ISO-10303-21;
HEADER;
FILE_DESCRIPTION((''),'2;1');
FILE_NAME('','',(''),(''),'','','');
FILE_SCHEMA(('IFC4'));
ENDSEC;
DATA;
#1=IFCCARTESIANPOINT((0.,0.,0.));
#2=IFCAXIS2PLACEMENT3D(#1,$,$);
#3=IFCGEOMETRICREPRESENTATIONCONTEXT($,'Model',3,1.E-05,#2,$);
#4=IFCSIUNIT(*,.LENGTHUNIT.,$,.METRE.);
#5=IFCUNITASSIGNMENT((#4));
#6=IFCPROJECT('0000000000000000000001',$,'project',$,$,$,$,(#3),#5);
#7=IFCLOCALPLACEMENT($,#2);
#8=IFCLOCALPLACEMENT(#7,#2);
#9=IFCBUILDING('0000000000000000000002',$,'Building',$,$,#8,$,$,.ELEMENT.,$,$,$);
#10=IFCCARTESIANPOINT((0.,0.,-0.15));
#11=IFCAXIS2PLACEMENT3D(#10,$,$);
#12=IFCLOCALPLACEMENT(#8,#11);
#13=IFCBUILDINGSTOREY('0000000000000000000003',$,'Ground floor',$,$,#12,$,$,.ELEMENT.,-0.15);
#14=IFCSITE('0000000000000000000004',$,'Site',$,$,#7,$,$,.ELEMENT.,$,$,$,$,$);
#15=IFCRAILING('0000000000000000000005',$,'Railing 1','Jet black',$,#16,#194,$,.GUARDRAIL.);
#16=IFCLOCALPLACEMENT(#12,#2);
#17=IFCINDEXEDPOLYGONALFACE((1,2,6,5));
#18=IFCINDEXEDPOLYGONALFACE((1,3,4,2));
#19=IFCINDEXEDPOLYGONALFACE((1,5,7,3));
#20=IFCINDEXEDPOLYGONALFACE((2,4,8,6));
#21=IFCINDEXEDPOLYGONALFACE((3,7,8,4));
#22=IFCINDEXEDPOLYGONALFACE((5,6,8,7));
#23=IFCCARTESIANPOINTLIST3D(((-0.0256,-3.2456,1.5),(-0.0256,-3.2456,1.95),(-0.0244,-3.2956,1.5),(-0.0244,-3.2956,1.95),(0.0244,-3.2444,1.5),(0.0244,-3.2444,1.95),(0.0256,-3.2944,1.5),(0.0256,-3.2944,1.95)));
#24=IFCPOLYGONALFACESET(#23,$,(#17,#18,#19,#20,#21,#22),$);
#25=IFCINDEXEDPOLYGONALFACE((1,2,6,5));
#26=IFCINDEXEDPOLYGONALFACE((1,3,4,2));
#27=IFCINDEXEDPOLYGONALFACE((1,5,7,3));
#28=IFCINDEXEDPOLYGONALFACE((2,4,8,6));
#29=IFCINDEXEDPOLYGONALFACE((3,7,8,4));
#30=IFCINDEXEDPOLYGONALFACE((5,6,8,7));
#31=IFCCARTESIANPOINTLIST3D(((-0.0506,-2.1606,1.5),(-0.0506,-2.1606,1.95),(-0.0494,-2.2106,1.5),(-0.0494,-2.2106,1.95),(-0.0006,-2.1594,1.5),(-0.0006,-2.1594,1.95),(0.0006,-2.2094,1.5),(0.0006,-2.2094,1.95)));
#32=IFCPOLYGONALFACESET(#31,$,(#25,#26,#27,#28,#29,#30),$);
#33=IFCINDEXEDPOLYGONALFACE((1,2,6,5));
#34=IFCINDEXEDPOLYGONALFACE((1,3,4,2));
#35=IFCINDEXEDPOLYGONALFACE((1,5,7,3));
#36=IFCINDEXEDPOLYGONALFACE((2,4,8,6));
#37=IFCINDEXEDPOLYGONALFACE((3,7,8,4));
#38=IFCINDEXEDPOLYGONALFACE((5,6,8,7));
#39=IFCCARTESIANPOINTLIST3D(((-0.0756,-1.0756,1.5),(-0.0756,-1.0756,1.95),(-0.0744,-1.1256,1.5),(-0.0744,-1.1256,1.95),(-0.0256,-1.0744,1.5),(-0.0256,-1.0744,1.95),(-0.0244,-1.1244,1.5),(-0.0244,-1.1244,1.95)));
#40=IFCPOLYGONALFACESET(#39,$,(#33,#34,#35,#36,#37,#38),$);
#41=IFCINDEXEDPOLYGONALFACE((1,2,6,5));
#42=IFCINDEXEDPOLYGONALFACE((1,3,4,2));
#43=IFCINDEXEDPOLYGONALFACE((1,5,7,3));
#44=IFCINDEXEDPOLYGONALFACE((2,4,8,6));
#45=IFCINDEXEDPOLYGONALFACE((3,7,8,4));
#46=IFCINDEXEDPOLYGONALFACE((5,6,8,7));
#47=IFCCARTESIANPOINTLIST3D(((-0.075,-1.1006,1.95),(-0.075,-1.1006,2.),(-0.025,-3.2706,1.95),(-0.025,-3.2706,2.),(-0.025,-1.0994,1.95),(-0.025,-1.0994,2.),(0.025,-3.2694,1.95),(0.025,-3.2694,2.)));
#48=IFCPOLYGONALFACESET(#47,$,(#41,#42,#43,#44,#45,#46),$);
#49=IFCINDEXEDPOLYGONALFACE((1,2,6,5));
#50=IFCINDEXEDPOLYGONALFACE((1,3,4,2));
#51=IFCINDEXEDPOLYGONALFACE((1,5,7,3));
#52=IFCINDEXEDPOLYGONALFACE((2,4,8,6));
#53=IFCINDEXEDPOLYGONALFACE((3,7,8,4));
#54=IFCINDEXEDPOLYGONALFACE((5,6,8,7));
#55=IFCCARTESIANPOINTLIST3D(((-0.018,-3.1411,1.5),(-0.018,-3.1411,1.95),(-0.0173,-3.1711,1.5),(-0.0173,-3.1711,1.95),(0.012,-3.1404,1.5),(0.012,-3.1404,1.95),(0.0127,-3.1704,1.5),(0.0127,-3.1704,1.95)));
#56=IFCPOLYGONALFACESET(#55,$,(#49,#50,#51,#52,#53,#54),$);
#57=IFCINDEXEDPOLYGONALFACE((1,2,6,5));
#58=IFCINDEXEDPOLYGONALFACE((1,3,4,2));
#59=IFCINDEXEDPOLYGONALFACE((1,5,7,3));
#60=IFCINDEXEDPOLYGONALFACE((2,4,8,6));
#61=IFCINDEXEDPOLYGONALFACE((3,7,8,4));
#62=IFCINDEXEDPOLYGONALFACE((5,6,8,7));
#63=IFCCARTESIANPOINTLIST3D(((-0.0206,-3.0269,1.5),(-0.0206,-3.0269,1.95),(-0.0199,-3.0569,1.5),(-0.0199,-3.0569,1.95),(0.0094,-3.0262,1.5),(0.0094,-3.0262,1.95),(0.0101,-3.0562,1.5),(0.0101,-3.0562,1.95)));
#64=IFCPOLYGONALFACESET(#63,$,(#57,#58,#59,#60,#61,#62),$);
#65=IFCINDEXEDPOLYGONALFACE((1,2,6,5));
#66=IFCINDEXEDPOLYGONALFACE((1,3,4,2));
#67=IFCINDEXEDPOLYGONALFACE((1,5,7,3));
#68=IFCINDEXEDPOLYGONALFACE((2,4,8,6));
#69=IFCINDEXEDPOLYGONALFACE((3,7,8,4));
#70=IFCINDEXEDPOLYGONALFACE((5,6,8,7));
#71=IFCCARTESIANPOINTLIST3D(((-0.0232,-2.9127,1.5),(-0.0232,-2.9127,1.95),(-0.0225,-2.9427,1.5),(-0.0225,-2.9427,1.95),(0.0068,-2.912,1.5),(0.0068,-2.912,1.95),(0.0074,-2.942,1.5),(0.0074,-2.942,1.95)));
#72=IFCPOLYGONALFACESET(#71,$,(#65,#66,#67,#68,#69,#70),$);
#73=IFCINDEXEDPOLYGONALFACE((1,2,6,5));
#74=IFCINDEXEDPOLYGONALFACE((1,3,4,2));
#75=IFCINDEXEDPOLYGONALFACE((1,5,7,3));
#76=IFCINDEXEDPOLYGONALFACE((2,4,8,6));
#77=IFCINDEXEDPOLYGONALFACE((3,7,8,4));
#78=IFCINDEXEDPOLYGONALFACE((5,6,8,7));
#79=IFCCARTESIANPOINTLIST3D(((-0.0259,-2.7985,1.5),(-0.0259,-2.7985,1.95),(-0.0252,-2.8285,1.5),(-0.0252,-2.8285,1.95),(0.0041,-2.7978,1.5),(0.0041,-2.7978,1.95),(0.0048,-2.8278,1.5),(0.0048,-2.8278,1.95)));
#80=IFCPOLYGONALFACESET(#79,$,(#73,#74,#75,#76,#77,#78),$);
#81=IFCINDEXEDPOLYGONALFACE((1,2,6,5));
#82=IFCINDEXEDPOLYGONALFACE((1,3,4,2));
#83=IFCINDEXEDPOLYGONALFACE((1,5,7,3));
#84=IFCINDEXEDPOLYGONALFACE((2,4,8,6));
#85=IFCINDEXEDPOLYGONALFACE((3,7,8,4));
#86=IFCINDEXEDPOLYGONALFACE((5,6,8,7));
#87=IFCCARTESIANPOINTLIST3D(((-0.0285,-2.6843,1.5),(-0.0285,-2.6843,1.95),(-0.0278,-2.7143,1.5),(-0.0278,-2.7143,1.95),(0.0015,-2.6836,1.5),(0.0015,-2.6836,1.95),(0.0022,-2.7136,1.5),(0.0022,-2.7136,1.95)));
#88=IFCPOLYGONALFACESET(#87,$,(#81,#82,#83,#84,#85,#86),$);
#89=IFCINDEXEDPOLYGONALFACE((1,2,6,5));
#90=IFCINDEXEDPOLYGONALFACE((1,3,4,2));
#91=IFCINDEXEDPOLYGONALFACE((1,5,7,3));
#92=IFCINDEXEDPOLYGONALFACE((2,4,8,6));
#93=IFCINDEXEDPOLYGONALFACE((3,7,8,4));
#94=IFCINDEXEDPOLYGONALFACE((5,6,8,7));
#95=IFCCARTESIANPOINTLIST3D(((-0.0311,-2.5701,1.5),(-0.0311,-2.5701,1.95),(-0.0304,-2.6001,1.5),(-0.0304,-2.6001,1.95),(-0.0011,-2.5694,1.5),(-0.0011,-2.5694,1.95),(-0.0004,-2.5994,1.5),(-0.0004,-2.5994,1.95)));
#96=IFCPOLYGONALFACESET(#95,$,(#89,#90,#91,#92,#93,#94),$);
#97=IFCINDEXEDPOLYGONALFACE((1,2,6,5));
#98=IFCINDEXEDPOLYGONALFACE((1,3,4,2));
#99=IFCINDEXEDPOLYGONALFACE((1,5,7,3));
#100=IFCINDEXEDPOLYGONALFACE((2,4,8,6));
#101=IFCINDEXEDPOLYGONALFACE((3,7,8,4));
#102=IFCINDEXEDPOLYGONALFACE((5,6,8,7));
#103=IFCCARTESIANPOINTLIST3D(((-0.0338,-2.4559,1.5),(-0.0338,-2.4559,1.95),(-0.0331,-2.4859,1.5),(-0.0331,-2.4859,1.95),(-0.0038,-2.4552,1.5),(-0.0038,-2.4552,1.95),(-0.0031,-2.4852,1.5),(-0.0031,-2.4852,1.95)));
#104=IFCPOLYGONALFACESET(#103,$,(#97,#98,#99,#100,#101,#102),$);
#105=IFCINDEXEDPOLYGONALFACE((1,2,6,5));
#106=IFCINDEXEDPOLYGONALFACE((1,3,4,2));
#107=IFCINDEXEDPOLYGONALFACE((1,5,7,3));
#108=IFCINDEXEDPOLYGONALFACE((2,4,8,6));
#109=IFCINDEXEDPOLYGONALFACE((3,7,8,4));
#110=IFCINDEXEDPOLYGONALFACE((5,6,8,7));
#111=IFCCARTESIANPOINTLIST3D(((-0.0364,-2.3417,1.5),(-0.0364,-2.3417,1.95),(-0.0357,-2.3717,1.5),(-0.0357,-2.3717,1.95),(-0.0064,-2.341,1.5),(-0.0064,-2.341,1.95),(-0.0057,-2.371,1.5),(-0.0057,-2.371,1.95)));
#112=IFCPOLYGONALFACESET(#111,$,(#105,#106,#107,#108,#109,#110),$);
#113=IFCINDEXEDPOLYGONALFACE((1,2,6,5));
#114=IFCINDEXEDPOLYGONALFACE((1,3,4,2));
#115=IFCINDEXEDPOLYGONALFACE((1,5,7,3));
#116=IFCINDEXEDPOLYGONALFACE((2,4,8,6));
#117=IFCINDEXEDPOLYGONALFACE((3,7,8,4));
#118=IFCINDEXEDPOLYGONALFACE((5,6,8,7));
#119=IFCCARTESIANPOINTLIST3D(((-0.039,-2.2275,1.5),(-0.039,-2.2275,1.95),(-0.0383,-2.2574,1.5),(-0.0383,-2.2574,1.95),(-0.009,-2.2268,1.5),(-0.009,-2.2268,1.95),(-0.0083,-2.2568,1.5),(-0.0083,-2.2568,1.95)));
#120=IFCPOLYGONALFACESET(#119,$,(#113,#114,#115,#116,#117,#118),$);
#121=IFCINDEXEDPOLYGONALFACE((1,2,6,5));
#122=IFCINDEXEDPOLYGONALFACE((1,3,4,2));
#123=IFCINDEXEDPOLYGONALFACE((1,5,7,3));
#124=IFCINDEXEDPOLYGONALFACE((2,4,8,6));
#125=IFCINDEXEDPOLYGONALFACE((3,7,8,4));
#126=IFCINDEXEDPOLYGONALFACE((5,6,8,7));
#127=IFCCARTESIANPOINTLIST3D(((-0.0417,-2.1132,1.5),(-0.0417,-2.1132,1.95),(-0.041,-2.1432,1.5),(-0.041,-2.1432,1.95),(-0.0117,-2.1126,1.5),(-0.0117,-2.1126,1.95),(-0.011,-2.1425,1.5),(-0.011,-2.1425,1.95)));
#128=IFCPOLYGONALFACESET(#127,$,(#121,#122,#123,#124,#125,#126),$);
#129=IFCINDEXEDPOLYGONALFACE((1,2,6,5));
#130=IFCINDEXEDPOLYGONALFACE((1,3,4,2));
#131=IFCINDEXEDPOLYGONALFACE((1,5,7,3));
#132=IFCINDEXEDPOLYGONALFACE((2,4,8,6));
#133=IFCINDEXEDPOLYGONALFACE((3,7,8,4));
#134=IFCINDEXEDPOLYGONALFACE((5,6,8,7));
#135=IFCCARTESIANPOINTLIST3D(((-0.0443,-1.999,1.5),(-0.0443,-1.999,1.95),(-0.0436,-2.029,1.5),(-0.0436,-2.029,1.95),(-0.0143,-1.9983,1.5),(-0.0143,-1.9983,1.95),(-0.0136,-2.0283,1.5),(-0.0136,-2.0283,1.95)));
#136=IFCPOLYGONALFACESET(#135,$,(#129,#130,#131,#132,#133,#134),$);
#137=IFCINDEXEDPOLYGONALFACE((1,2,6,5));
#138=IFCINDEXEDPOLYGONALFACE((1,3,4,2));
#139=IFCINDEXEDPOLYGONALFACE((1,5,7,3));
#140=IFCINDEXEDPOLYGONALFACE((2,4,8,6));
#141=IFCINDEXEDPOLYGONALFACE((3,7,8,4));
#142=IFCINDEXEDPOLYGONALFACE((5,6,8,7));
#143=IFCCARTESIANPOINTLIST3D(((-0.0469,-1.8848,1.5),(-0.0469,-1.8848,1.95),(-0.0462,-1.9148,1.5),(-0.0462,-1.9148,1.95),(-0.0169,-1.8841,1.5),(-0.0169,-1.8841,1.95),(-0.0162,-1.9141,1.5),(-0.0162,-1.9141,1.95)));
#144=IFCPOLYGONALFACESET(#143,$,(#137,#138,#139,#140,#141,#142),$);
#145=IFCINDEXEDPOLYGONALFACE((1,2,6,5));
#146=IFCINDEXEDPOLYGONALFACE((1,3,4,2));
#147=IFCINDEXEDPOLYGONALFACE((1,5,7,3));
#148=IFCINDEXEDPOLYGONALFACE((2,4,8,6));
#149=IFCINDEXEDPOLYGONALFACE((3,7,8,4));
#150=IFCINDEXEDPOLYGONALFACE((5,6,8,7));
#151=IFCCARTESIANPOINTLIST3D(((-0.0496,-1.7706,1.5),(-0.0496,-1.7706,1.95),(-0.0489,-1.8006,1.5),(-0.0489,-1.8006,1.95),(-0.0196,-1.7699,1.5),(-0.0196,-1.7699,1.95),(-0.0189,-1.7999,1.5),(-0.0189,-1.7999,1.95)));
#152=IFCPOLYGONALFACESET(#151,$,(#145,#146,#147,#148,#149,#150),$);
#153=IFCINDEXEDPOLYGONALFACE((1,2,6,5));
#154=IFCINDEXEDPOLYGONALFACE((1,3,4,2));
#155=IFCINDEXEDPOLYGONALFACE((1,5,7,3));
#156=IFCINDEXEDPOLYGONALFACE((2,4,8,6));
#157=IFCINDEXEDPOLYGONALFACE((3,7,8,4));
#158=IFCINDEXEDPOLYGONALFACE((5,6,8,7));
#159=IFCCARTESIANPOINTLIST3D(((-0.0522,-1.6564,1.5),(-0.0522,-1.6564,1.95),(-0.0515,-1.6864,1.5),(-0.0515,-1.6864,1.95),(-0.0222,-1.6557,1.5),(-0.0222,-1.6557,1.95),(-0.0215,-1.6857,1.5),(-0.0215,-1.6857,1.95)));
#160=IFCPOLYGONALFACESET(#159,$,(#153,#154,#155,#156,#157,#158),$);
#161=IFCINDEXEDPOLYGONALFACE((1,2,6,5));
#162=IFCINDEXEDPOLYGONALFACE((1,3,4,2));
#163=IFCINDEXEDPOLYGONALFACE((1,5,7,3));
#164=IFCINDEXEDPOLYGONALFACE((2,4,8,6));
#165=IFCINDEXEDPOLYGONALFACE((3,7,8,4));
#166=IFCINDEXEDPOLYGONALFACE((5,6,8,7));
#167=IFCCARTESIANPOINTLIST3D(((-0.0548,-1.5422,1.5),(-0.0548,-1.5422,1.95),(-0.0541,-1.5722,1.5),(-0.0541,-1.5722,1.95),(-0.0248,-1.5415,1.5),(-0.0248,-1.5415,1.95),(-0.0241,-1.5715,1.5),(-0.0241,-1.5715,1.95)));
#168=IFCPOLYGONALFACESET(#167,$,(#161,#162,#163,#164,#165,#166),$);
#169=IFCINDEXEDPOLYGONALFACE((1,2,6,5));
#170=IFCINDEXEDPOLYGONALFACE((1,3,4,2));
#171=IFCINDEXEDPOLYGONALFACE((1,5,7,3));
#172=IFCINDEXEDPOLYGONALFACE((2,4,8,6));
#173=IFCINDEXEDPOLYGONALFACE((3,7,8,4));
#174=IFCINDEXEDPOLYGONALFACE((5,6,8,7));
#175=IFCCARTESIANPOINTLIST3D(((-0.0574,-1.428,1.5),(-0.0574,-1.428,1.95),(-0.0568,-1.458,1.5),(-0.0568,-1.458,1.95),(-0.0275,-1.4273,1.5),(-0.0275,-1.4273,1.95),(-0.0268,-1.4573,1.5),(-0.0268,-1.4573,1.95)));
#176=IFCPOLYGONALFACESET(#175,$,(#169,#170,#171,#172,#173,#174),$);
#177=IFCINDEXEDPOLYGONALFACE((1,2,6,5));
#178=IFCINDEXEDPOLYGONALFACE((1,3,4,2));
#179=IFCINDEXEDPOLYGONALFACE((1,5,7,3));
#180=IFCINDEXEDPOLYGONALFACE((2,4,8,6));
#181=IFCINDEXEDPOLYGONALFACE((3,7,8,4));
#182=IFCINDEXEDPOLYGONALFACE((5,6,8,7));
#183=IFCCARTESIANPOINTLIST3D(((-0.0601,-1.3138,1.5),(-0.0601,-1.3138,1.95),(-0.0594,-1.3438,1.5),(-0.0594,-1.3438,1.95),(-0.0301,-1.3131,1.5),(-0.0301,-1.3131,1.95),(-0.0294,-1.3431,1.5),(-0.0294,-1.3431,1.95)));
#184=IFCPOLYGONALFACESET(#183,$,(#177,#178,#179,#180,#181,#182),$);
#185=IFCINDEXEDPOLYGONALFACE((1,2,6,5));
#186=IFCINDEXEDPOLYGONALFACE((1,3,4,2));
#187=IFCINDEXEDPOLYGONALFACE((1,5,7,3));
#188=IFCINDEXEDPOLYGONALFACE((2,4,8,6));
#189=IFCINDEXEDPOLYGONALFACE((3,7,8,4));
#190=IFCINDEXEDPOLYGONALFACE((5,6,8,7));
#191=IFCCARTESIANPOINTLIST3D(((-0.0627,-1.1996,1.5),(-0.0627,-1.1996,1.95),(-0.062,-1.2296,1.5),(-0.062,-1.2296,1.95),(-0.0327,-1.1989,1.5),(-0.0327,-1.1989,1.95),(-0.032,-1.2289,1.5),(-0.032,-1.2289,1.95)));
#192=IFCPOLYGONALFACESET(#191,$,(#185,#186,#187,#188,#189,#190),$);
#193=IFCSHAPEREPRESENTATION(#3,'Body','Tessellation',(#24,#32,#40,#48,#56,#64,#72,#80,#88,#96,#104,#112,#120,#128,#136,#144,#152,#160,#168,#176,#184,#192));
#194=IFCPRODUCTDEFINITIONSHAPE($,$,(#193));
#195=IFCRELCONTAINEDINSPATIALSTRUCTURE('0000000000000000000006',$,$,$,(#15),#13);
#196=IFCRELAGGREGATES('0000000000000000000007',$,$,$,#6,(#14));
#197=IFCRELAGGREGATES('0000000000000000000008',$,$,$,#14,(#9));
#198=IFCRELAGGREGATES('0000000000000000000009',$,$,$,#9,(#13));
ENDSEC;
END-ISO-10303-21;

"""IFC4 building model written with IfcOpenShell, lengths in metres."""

from ifc_helpers import new_model, si_unit, frame, frame_2d, origin, origin_2d, place, context, project, spatial, polyline, rectangle, outline, extrude, element, save


model = new_model("IFC4")

# Units and contexts
model_context = context("Model", 3, precision=1e-05, world=origin())
ifc_project = project(units=[si_unit("LENGTHUNIT", "METRE")], contexts=[model_context])

# Site, building, storey
site_placement = place(None, origin())
site = spatial("IfcSite", under=ifc_project, at=site_placement, Name="Site", CompositionType="ELEMENT")
building_placement = place(site_placement, origin())
building = spatial("IfcBuilding", under=site, at=building_placement, Name="Building", CompositionType="ELEMENT")
storey_placement = place(building_placement, frame((0.0, 0.0, -0.15)))
storey = spatial("IfcBuildingStorey", under=building, at=storey_placement, Name="Ground floor", CompositionType="ELEMENT", Elevation=-0.15)

# Railing
railing_1_placement = place(storey_placement, frame((0.0, -3.27, 1.5), z_axis=(0.0, 0.0, 1.0), x_axis=(-0.023035, 0.999735, 0.0)))
element("IfcRailing", 1, at=railing_1_placement, inside=storey, Name="Railing 1", Description="Jet black", PredefinedType="GUARDRAIL", context=model_context, shape_type="SweptSolid", body=[
    extrude(rectangle(XDim=0.05, YDim=0.05, at=origin_2d()), origin(), (0.0, 0.0, 1.0), 0.45),
    extrude(rectangle(XDim=0.05, YDim=0.05, at=frame_2d((1.0853, 0.0))), origin(), (0.0, 0.0, 1.0), 0.45),
    extrude(rectangle(XDim=0.05, YDim=0.05, at=frame_2d((2.1706, 0.0))), origin(), (0.0, 0.0, 1.0), 0.45),
    extrude(outline(polyline([(0.0, 0.45), (2.1706, 0.45), (2.1706, 0.5), (0.0, 0.5), (0.0, 0.45)])), frame((0.0, 0.025, 0.0), z_axis=(0.0, -1.0, 0.0), x_axis=(1.0, 0.0, 0.0)), (0.0, 0.0, 1.0), 0.05),
    extrude(rectangle(XDim=0.03, YDim=0.03, at=frame_2d((0.1142, 0.0))), origin(), (0.0, 0.0, 1.0), 0.45),
    extrude(rectangle(XDim=0.03, YDim=0.03, at=frame_2d((0.2285, 0.0))), origin(), (0.0, 0.0, 1.0), 0.45),
    extrude(rectangle(XDim=0.03, YDim=0.03, at=frame_2d((0.3427, 0.0))), origin(), (0.0, 0.0, 1.0), 0.45),
    extrude(rectangle(XDim=0.03, YDim=0.03, at=frame_2d((0.457, 0.0))), origin(), (0.0, 0.0, 1.0), 0.45),
    extrude(rectangle(XDim=0.03, YDim=0.03, at=frame_2d((0.5712, 0.0))), origin(), (0.0, 0.0, 1.0), 0.45),
    extrude(rectangle(XDim=0.03, YDim=0.03, at=frame_2d((0.6854, 0.0))), origin(), (0.0, 0.0, 1.0), 0.45),
    extrude(rectangle(XDim=0.03, YDim=0.03, at=frame_2d((0.7997, 0.0))), origin(), (0.0, 0.0, 1.0), 0.45),
    extrude(rectangle(XDim=0.03, YDim=0.03, at=frame_2d((0.9139, 0.0))), origin(), (0.0, 0.0, 1.0), 0.45),
    extrude(rectangle(XDim=0.03, YDim=0.03, at=frame_2d((1.0282, 0.0))), origin(), (0.0, 0.0, 1.0), 0.45),
    extrude(rectangle(XDim=0.03, YDim=0.03, at=frame_2d((1.1424, 0.0))), origin(), (0.0, 0.0, 1.0), 0.45),
    extrude(rectangle(XDim=0.03, YDim=0.03, at=frame_2d((1.2566, 0.0))), origin(), (0.0, 0.0, 1.0), 0.45),
    extrude(rectangle(XDim=0.03, YDim=0.03, at=frame_2d((1.3709, 0.0))), origin(), (0.0, 0.0, 1.0), 0.45),
    extrude(rectangle(XDim=0.03, YDim=0.03, at=frame_2d((1.4851, 0.0))), origin(), (0.0, 0.0, 1.0), 0.45),
    extrude(rectangle(XDim=0.03, YDim=0.03, at=frame_2d((1.5994, 0.0))), origin(), (0.0, 0.0, 1.0), 0.45),
    extrude(rectangle(XDim=0.03, YDim=0.03, at=frame_2d((1.7136, 0.0))), origin(), (0.0, 0.0, 1.0), 0.45),
    extrude(rectangle(XDim=0.03, YDim=0.03, at=frame_2d((1.8279, 0.0))), origin(), (0.0, 0.0, 1.0), 0.45),
    extrude(rectangle(XDim=0.03, YDim=0.03, at=frame_2d((1.9421, 0.0))), origin(), (0.0, 0.0, 1.0), 0.45),
    extrude(rectangle(XDim=0.03, YDim=0.03, at=frame_2d((2.0563, 0.0))), origin(), (0.0, 0.0, 1.0), 0.45),
])

save(model, "model.ifc")
